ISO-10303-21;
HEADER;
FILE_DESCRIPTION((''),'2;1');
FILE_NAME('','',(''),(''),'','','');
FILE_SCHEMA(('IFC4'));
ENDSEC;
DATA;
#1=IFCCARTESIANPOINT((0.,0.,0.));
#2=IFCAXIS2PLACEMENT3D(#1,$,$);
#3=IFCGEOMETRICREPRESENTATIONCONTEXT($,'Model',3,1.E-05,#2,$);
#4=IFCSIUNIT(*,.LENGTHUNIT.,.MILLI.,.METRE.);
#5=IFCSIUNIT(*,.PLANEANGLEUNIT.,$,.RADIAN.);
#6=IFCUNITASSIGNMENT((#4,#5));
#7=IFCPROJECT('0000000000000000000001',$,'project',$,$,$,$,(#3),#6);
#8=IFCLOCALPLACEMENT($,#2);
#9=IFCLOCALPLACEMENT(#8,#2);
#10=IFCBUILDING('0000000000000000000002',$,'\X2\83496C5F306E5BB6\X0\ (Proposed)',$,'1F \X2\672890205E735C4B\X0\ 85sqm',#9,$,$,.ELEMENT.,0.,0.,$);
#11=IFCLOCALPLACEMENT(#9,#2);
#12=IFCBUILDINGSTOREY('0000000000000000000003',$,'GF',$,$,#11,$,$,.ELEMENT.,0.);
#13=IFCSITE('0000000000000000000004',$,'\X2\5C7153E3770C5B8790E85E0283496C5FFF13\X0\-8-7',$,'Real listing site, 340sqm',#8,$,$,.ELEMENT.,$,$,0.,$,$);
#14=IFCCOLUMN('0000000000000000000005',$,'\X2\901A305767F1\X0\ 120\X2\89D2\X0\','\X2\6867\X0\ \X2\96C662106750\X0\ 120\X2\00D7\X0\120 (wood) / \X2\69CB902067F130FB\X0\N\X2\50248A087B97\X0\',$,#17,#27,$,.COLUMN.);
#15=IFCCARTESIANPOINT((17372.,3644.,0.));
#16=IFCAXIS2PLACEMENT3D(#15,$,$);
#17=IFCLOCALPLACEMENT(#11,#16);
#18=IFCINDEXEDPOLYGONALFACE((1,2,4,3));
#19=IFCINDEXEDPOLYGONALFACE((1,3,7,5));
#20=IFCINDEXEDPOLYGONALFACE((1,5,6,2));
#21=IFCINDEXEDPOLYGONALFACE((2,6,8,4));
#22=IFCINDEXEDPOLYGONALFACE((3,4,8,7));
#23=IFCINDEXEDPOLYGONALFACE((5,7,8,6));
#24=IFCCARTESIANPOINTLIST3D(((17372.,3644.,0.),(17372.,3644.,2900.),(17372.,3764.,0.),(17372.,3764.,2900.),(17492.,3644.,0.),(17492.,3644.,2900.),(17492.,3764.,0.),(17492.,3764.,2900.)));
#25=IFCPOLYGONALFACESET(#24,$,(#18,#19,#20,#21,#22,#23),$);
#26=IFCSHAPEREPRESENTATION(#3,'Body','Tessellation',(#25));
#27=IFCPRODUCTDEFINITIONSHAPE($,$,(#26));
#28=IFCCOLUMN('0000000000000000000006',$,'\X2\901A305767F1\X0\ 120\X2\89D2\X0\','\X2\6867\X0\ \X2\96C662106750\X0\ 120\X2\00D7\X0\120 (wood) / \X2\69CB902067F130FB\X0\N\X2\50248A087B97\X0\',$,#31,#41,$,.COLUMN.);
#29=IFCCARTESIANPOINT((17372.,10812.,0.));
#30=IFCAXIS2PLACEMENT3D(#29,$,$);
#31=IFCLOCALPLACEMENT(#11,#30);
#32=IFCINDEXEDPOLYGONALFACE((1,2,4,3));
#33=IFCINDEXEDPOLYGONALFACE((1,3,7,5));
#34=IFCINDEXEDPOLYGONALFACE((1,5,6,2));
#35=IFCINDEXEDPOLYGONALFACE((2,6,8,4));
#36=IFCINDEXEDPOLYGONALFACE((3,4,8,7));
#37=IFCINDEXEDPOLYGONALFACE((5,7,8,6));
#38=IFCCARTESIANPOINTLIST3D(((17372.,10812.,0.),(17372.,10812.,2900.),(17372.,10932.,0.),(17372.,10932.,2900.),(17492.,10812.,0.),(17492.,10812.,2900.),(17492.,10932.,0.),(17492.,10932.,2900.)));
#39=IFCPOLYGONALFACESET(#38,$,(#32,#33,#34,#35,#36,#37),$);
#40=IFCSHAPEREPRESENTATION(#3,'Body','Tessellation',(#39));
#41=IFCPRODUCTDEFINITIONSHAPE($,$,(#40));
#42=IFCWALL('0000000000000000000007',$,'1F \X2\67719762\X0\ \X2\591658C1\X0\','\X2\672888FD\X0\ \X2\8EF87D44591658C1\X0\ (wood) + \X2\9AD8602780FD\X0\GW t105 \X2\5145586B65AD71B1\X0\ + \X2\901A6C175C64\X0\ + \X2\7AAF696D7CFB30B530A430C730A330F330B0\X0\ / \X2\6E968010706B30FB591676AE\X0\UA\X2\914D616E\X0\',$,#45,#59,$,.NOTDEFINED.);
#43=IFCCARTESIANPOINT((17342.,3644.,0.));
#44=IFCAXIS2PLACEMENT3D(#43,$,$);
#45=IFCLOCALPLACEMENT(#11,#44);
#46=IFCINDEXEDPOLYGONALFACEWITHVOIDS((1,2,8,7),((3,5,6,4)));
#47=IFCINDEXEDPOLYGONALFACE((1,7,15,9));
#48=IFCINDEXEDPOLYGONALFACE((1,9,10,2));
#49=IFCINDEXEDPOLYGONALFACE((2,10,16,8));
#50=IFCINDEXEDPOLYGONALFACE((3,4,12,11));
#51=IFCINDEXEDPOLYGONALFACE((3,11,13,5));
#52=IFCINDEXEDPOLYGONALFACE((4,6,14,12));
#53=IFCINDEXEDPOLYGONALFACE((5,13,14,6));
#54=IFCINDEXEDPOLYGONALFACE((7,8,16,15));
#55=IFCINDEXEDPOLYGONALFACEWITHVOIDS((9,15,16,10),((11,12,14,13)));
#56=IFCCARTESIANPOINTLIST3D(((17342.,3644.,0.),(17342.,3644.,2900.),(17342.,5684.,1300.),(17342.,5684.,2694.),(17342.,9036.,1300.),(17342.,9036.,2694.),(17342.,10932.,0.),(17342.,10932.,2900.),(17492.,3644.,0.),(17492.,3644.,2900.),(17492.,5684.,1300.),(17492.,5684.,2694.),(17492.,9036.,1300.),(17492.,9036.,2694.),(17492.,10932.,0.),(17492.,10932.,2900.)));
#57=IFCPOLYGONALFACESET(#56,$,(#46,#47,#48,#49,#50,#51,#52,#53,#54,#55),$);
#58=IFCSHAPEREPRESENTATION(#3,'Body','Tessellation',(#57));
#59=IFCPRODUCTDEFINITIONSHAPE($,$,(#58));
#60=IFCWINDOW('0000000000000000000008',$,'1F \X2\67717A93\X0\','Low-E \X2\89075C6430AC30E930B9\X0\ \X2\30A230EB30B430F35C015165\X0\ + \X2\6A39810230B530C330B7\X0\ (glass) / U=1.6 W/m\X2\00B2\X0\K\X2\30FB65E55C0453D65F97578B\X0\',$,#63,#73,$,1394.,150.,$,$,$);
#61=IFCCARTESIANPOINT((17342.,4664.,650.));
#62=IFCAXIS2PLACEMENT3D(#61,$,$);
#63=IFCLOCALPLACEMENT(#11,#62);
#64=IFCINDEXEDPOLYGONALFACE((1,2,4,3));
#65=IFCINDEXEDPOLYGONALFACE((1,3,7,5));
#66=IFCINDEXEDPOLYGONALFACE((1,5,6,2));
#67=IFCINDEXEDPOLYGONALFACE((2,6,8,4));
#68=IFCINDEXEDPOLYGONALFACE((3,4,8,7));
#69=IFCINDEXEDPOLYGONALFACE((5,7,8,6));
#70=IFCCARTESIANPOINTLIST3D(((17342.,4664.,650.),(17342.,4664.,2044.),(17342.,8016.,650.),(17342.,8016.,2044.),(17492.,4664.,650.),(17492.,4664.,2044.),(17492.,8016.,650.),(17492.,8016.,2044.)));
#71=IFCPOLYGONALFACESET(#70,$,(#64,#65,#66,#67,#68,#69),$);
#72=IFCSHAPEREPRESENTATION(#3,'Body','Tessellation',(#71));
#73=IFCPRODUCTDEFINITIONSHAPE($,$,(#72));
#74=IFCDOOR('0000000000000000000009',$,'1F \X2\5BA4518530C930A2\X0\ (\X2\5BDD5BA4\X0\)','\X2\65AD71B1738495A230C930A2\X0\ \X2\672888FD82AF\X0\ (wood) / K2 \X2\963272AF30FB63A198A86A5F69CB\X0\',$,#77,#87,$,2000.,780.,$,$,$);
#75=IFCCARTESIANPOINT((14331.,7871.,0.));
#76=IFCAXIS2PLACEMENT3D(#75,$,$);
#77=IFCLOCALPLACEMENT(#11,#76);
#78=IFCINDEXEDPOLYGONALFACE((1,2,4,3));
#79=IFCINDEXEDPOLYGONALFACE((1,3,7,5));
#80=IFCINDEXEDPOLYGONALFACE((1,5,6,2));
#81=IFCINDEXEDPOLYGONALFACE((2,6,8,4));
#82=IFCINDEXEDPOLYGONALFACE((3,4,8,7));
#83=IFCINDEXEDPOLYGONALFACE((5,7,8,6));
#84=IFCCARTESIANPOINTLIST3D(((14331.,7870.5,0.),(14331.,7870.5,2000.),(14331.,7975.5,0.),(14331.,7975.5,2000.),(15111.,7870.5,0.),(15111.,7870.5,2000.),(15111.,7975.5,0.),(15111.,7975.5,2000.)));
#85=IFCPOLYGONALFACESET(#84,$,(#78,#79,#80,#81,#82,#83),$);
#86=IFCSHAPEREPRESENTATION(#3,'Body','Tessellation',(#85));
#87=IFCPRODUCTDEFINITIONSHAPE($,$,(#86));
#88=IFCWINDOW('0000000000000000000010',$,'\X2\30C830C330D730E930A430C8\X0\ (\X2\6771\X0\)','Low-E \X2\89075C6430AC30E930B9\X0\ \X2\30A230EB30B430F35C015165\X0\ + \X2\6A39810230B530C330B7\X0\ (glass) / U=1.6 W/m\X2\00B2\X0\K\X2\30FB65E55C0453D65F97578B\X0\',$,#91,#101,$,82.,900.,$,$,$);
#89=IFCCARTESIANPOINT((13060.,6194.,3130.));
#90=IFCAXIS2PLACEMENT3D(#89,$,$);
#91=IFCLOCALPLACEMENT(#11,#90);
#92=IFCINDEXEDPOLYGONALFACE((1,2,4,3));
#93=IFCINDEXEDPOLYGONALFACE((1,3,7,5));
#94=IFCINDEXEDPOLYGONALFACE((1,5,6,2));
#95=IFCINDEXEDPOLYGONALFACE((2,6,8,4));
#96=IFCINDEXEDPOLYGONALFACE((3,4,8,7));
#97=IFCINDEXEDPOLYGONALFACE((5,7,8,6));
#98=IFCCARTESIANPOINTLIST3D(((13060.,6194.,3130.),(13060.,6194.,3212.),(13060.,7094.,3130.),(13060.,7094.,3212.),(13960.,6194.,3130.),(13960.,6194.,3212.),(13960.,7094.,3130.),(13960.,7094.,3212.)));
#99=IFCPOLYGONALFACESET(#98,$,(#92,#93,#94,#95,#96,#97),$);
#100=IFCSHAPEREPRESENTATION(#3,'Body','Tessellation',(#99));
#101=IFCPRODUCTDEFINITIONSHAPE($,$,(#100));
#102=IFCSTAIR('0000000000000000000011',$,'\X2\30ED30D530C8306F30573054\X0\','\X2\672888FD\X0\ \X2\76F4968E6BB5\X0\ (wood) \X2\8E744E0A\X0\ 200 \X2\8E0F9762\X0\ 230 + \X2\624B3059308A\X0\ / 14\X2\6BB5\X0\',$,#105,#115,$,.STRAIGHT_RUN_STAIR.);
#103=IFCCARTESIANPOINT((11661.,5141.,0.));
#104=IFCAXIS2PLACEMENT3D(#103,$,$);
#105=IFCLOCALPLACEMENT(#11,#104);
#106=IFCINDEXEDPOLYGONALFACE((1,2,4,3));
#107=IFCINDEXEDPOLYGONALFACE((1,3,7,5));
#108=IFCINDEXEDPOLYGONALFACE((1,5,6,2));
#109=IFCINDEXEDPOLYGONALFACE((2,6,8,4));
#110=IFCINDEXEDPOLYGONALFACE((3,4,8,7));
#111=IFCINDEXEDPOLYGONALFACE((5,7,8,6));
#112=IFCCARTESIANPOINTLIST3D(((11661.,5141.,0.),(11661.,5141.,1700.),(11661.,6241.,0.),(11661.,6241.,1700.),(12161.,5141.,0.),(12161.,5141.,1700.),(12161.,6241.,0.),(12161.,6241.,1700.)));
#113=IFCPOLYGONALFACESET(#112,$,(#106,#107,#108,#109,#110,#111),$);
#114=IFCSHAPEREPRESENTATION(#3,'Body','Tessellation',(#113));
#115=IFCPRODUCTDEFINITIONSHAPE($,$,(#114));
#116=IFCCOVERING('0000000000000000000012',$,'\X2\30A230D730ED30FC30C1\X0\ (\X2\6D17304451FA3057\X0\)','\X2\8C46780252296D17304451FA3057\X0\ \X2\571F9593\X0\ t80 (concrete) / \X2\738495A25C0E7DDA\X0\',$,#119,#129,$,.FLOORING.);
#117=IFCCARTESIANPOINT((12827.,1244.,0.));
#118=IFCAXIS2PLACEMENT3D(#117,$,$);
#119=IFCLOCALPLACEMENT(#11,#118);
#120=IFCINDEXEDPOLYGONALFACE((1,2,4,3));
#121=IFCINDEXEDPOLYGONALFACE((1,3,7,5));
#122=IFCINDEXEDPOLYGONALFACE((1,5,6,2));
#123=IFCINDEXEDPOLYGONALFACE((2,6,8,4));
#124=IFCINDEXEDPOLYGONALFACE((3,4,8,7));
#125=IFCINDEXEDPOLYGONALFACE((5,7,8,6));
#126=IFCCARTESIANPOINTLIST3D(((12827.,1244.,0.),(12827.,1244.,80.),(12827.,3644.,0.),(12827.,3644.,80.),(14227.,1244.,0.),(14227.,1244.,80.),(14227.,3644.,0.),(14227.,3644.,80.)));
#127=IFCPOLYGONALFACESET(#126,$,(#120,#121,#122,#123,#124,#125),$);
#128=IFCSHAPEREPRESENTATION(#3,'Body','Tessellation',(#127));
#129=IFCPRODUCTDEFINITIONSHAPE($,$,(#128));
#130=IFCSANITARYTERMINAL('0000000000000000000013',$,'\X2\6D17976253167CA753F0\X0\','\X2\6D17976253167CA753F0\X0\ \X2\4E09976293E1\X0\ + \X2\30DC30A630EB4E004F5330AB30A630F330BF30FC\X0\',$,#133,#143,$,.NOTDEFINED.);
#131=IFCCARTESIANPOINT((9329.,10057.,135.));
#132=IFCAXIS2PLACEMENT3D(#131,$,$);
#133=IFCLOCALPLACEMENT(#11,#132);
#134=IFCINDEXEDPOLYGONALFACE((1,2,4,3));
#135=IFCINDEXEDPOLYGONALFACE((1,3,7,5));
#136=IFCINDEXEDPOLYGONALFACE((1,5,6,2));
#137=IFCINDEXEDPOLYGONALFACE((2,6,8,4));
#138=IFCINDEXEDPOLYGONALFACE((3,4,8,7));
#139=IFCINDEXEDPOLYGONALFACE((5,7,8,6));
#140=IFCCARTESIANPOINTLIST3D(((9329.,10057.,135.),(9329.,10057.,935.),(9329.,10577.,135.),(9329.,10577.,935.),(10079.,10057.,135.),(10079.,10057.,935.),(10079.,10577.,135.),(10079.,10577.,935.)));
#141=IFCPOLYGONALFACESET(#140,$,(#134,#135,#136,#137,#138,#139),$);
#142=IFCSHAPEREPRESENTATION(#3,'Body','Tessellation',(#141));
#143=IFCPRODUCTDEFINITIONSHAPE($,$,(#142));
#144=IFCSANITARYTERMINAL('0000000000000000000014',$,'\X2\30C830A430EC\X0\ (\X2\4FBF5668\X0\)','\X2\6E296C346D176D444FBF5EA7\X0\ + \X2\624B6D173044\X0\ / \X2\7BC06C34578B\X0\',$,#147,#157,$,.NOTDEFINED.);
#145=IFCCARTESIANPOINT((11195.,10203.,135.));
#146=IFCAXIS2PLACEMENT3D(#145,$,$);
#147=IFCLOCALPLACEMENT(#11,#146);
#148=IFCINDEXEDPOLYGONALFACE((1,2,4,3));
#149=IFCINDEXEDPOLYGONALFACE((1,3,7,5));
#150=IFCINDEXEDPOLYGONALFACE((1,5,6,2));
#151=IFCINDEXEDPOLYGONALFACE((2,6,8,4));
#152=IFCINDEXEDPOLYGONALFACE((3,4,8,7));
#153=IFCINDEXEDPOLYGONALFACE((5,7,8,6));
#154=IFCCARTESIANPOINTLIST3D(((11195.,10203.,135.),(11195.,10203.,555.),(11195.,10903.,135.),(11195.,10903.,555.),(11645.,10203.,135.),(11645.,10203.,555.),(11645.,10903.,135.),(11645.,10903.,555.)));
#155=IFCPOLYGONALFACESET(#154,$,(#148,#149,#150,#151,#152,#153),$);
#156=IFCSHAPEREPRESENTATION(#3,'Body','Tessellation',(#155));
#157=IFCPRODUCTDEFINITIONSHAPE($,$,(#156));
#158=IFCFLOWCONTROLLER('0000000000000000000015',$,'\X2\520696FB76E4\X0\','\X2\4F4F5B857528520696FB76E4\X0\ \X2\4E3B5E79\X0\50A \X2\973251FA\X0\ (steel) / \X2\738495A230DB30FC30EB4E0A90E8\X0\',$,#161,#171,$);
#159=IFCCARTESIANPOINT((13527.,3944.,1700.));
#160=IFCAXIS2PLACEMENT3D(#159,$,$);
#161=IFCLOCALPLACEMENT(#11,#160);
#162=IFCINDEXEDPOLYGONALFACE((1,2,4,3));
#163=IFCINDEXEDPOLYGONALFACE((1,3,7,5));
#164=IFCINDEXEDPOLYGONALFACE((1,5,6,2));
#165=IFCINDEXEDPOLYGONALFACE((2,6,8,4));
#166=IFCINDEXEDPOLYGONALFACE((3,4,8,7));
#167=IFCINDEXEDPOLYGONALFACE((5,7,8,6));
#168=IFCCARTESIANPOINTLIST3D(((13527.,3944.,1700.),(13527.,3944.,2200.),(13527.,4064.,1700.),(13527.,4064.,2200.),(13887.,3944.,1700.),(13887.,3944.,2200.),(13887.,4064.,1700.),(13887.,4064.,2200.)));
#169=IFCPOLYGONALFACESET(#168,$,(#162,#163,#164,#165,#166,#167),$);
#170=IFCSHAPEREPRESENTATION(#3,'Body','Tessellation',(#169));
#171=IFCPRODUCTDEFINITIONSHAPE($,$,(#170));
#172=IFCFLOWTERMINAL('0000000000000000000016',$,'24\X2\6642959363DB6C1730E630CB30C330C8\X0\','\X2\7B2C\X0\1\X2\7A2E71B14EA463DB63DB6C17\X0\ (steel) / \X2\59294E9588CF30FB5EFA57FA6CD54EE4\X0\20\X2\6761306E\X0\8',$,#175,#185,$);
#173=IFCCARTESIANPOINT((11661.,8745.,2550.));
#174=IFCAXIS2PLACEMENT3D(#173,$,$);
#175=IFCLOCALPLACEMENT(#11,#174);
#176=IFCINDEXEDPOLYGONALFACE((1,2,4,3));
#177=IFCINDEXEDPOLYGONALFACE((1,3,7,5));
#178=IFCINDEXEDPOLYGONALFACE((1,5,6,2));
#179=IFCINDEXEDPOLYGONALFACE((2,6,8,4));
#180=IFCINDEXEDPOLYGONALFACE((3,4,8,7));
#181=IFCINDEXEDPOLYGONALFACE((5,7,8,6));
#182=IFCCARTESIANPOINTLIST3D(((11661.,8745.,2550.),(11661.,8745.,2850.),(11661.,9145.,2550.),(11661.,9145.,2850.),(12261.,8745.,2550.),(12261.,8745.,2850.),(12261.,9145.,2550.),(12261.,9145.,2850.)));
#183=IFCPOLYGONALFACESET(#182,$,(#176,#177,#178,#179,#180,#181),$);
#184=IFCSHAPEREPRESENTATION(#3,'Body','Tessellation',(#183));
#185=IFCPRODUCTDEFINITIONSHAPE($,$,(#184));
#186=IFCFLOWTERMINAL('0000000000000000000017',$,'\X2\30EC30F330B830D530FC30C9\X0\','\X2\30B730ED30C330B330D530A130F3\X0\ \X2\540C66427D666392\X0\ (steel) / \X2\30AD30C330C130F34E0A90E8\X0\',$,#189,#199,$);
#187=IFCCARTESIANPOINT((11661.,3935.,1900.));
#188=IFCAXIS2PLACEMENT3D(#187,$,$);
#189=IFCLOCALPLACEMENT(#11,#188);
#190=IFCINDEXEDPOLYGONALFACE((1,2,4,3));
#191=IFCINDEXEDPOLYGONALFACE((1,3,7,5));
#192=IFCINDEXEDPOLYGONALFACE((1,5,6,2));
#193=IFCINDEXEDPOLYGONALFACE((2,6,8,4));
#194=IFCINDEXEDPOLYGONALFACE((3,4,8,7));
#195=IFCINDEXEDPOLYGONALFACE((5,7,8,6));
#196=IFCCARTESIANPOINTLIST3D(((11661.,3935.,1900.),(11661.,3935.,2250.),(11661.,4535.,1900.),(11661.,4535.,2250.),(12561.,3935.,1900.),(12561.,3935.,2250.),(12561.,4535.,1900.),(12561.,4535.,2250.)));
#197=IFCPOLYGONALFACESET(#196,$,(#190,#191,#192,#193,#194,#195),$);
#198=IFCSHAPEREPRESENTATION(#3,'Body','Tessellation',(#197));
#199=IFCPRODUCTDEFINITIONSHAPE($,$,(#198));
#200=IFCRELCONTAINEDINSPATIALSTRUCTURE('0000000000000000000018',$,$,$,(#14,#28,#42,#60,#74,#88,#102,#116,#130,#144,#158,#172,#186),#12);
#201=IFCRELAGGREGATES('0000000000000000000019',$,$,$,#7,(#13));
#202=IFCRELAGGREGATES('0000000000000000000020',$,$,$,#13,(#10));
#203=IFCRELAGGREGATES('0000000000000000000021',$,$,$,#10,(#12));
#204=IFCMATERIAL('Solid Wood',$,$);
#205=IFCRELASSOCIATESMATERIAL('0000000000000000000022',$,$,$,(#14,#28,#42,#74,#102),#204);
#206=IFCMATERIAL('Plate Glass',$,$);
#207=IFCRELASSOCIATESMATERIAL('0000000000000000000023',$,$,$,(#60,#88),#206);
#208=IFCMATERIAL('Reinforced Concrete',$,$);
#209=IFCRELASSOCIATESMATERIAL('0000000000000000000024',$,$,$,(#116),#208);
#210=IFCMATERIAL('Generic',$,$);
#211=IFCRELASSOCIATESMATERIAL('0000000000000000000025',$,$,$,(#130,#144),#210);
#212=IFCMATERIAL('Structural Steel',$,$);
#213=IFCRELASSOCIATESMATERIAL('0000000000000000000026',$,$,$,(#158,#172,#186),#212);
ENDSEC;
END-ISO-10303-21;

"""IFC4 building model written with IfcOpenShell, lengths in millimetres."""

from ifc_helpers import new_model, si_unit, frame, frame_2d, origin, place, context, project, spatial, rectangle, extrude, material, element, fill, save


model = new_model("IFC4")

# Units and contexts
model_context = context("Model", 3, precision=1e-05, world=origin())
ifc_project = project(units=[si_unit("LENGTHUNIT", "METRE", prefix="MILLI"), si_unit("PLANEANGLEUNIT", "RADIAN")], contexts=[model_context])

# Site, building, storey
site_placement = place(None, origin())
site = spatial("IfcSite", under=ifc_project, at=site_placement, Name="山口県宇部市草江３-8-7", ObjectType="Real listing site, 340sqm", CompositionType="ELEMENT", RefElevation=0.0)
building_placement = place(site_placement, origin())
building = spatial("IfcBuilding", under=site, at=building_placement, Name="草江の家 (Proposed)", ObjectType="1F 木造平屋 85sqm", CompositionType="ELEMENT", ElevationOfRefHeight=0.0, ElevationOfTerrain=0.0)
storey_placement = place(building_placement, origin())
storey = spatial("IfcBuildingStorey", under=building, at=storey_placement, Name="GF", CompositionType="ELEMENT", Elevation=0.0)

# Columns
ifc_material_1 = material(Name="Solid Wood")
column_1_placement = place(storey_placement, frame((17372.0, 3644.0, 0.0)))
element("IfcColumn", 1, at=column_1_placement, inside=storey, material=ifc_material_1, Name="通し柱 120角", Description="桧 集成材 120×120 (wood) / 構造柱・N値計算", PredefinedType="COLUMN", context=model_context, shape_type="SweptSolid", body=[
    extrude(rectangle(XDim=120.0, YDim=120.0, at=frame_2d((60.0, 60.0))), frame((17372.0, 3644.0, 0.0)), (0.0, 0.0, 1.0), 2900.0),
])
column_2_placement = place(storey_placement, frame((17372.0, 10812.0, 0.0)))
element("IfcColumn", 2, at=column_2_placement, inside=storey, material=ifc_material_1, Name="通し柱 120角", Description="桧 集成材 120×120 (wood) / 構造柱・N値計算", PredefinedType="COLUMN", context=model_context, shape_type="SweptSolid", body=[
    extrude(rectangle(XDim=120.0, YDim=120.0, at=frame_2d((60.0, 60.0))), frame((17372.0, 10812.0, 0.0)), (0.0, 0.0, 1.0), 2900.0),
])

# Wall, opening, window
wall_1_placement = place(storey_placement, frame((17342.0, 3644.0, 0.0)))
wall_1 = element("IfcWall", 3, at=wall_1_placement, inside=storey, material=ifc_material_1, Name="1F 東面 外壁", Description="木製 軸組外壁 (wood) + 高性能GW t105 充填断熱 + 通気層 + 窯業系サイディング / 準耐火・外皮UA配慮", PredefinedType="NOTDEFINED", context=model_context, shape_type="SweptSolid", body=[
    extrude(rectangle(XDim=150.0, YDim=7288.0, at=frame_2d((75.0, 3644.0))), frame((17342.0, 3644.0, 0.0)), (0.0, 0.0, 1.0), 2900.0),
])
opening_placement = place(storey_placement, frame((17342.0, 4664.0, 650.0)))
opening = element("IfcOpeningElement", 4, at=opening_placement, cuts=wall_1, PredefinedType="NOTDEFINED", context=model_context, shape_type="SweptSolid", body=[
    extrude(rectangle(XDim=150.0, YDim=3352.0, at=frame_2d((75.0, 1676.0))), frame((17342.0, 4664.0, 650.0)), (0.0, 0.0, 1.0), 1394.0),
])
ifc_material_2 = material(Name="Plate Glass")
window_1_placement = place(storey_placement, frame((17342.0, 4664.0, 650.0)))
window_1 = element("IfcWindow", 5, at=window_1_placement, inside=storey, material=ifc_material_2, Name="1F 東窓", Description="Low-E 複層ガラス アルゴン封入 + 樹脂サッシ (glass) / U=1.6 W/m²K・日射取得型", OverallHeight=1394.0, OverallWidth=150.0, context=model_context, shape_type="SweptSolid", body=[
    extrude(rectangle(XDim=150.0, YDim=3352.0, at=frame_2d((75.0, 1676.0))), frame((17342.0, 4664.0, 650.0)), (0.0, 0.0, 1.0), 1394.0),
])
fill(opening, window_1)

# Door
door_placement = place(storey_placement, frame((14331.0, 7871.0, 0.0)))
element("IfcDoor", 6, at=door_placement, inside=storey, material=ifc_material_1, Name="1F 室内ドア (寝室)", Description="断熱玄関ドア 木製芯 (wood) / K2 防犯・採風機構", OverallHeight=2000.0, OverallWidth=780.0, context=model_context, shape_type="SweptSolid", body=[
    extrude(rectangle(XDim=780.0, YDim=105.0, at=frame_2d((390.0, 52.0))), frame((14331.0, 7871.0, 0.0)), (0.0, 0.0, 1.0), 2000.0),
])

# Window
window_2_placement = place(storey_placement, frame((13060.0, 6194.0, 3130.0)))
element("IfcWindow", 7, at=window_2_placement, inside=storey, material=ifc_material_2, Name="トップライト (東)", Description="Low-E 複層ガラス アルゴン封入 + 樹脂サッシ (glass) / U=1.6 W/m²K・日射取得型", OverallHeight=82.0, OverallWidth=900.0, context=model_context, shape_type="SweptSolid", body=[
    extrude(rectangle(XDim=900.0, YDim=900.0, at=frame_2d((450.0, 450.0))), frame((13060.0, 6194.0, 3130.0)), (0.0, 0.0, 1.0), 82.0),
])

# Stair
stair_placement = place(storey_placement, frame((11661.0, 5141.0, 0.0)))
element("IfcStair", 8, at=stair_placement, inside=storey, material=ifc_material_1, Name="ロフトはしご", Description="木製 直階段 (wood) 蹴上 200 踏面 230 + 手すり / 14段", PredefinedType="STRAIGHT_RUN_STAIR", context=model_context, shape_type="SweptSolid", body=[
    extrude(rectangle(XDim=500.0, YDim=1100.0, at=frame_2d((250.0, 550.0))), frame((11661.0, 5141.0, 0.0)), (0.0, 0.0, 1.0), 1700.0),
])

# Covering
ifc_material_3 = material(Name="Reinforced Concrete")
covering_placement = place(storey_placement, frame((12827.0, 1244.0, 0.0)))
element("IfcCovering", 9, at=covering_placement, inside=storey, material=ifc_material_3, Name="アプローチ (洗い出し)", Description="豆砂利洗い出し 土間 t80 (concrete) / 玄関導線", PredefinedType="FLOORING", context=model_context, shape_type="SweptSolid", body=[
    extrude(rectangle(XDim=1400.0, YDim=2400.0, at=frame_2d((700.0, 1200.0))), frame((12827.0, 1244.0, 0.0)), (0.0, 0.0, 1.0), 80.0),
])

# Sanitary terminals
ifc_material_4 = material(Name="Generic")
sanitary_terminal_1_placement = place(storey_placement, frame((9329.0, 10057.0, 135.0)))
element("IfcSanitaryTerminal", 10, at=sanitary_terminal_1_placement, inside=storey, material=ifc_material_4, Name="洗面化粧台", Description="洗面化粧台 三面鏡 + ボウル一体カウンター", PredefinedType="NOTDEFINED", context=model_context, shape_type="SweptSolid", body=[
    extrude(rectangle(XDim=750.0, YDim=520.0, at=frame_2d((375.0, 260.0))), frame((9329.0, 10057.0, 135.0)), (0.0, 0.0, 1.0), 800.0),
])
sanitary_terminal_2_placement = place(storey_placement, frame((11195.0, 10203.0, 135.0)))
element("IfcSanitaryTerminal", 11, at=sanitary_terminal_2_placement, inside=storey, material=ifc_material_4, Name="トイレ (便器)", Description="温水洗浄便座 + 手洗い / 節水型", PredefinedType="NOTDEFINED", context=model_context, shape_type="SweptSolid", body=[
    extrude(rectangle(XDim=450.0, YDim=700.0, at=frame_2d((225.0, 350.0))), frame((11195.0, 10203.0, 135.0)), (0.0, 0.0, 1.0), 420.0),
])

# Flow controller
ifc_material_5 = material(Name="Structural Steel")
flow_controller_placement = place(storey_placement, frame((13527.0, 3944.0, 1700.0)))
element("IfcFlowController", 12, at=flow_controller_placement, inside=storey, material=ifc_material_5, Name="分電盤", Description="住宅用分電盤 主幹50A 露出 (steel) / 玄関ホール上部", context=model_context, shape_type="SweptSolid", body=[
    extrude(rectangle(XDim=360.0, YDim=120.0, at=frame_2d((180.0, 60.0))), frame((13527.0, 3944.0, 1700.0)), (0.0, 0.0, 1.0), 500.0),
])

# Flow terminals
flow_terminal_1_placement = place(storey_placement, frame((11661.0, 8745.0, 2550.0)))
element("IfcFlowTerminal", 13, at=flow_terminal_1_placement, inside=storey, material=ifc_material_5, Name="24時間換気ユニット", Description="第1種熱交換換気 (steel) / 天井裏・建基法令20条の8", context=model_context, shape_type="SweptSolid", body=[
    extrude(rectangle(XDim=600.0, YDim=400.0, at=frame_2d((300.0, 200.0))), frame((11661.0, 8745.0, 2550.0)), (0.0, 0.0, 1.0), 300.0),
])
flow_terminal_2_placement = place(storey_placement, frame((11661.0, 3935.0, 1900.0)))
element("IfcFlowTerminal", 14, at=flow_terminal_2_placement, inside=storey, material=ifc_material_5, Name="レンジフード", Description="シロッコファン 同時給排 (steel) / キッチン上部", context=model_context, shape_type="SweptSolid", body=[
    extrude(rectangle(XDim=900.0, YDim=600.0, at=frame_2d((450.0, 300.0))), frame((11661.0, 3935.0, 1900.0)), (0.0, 0.0, 1.0), 350.0),
])

save(model, "model.ifc")
